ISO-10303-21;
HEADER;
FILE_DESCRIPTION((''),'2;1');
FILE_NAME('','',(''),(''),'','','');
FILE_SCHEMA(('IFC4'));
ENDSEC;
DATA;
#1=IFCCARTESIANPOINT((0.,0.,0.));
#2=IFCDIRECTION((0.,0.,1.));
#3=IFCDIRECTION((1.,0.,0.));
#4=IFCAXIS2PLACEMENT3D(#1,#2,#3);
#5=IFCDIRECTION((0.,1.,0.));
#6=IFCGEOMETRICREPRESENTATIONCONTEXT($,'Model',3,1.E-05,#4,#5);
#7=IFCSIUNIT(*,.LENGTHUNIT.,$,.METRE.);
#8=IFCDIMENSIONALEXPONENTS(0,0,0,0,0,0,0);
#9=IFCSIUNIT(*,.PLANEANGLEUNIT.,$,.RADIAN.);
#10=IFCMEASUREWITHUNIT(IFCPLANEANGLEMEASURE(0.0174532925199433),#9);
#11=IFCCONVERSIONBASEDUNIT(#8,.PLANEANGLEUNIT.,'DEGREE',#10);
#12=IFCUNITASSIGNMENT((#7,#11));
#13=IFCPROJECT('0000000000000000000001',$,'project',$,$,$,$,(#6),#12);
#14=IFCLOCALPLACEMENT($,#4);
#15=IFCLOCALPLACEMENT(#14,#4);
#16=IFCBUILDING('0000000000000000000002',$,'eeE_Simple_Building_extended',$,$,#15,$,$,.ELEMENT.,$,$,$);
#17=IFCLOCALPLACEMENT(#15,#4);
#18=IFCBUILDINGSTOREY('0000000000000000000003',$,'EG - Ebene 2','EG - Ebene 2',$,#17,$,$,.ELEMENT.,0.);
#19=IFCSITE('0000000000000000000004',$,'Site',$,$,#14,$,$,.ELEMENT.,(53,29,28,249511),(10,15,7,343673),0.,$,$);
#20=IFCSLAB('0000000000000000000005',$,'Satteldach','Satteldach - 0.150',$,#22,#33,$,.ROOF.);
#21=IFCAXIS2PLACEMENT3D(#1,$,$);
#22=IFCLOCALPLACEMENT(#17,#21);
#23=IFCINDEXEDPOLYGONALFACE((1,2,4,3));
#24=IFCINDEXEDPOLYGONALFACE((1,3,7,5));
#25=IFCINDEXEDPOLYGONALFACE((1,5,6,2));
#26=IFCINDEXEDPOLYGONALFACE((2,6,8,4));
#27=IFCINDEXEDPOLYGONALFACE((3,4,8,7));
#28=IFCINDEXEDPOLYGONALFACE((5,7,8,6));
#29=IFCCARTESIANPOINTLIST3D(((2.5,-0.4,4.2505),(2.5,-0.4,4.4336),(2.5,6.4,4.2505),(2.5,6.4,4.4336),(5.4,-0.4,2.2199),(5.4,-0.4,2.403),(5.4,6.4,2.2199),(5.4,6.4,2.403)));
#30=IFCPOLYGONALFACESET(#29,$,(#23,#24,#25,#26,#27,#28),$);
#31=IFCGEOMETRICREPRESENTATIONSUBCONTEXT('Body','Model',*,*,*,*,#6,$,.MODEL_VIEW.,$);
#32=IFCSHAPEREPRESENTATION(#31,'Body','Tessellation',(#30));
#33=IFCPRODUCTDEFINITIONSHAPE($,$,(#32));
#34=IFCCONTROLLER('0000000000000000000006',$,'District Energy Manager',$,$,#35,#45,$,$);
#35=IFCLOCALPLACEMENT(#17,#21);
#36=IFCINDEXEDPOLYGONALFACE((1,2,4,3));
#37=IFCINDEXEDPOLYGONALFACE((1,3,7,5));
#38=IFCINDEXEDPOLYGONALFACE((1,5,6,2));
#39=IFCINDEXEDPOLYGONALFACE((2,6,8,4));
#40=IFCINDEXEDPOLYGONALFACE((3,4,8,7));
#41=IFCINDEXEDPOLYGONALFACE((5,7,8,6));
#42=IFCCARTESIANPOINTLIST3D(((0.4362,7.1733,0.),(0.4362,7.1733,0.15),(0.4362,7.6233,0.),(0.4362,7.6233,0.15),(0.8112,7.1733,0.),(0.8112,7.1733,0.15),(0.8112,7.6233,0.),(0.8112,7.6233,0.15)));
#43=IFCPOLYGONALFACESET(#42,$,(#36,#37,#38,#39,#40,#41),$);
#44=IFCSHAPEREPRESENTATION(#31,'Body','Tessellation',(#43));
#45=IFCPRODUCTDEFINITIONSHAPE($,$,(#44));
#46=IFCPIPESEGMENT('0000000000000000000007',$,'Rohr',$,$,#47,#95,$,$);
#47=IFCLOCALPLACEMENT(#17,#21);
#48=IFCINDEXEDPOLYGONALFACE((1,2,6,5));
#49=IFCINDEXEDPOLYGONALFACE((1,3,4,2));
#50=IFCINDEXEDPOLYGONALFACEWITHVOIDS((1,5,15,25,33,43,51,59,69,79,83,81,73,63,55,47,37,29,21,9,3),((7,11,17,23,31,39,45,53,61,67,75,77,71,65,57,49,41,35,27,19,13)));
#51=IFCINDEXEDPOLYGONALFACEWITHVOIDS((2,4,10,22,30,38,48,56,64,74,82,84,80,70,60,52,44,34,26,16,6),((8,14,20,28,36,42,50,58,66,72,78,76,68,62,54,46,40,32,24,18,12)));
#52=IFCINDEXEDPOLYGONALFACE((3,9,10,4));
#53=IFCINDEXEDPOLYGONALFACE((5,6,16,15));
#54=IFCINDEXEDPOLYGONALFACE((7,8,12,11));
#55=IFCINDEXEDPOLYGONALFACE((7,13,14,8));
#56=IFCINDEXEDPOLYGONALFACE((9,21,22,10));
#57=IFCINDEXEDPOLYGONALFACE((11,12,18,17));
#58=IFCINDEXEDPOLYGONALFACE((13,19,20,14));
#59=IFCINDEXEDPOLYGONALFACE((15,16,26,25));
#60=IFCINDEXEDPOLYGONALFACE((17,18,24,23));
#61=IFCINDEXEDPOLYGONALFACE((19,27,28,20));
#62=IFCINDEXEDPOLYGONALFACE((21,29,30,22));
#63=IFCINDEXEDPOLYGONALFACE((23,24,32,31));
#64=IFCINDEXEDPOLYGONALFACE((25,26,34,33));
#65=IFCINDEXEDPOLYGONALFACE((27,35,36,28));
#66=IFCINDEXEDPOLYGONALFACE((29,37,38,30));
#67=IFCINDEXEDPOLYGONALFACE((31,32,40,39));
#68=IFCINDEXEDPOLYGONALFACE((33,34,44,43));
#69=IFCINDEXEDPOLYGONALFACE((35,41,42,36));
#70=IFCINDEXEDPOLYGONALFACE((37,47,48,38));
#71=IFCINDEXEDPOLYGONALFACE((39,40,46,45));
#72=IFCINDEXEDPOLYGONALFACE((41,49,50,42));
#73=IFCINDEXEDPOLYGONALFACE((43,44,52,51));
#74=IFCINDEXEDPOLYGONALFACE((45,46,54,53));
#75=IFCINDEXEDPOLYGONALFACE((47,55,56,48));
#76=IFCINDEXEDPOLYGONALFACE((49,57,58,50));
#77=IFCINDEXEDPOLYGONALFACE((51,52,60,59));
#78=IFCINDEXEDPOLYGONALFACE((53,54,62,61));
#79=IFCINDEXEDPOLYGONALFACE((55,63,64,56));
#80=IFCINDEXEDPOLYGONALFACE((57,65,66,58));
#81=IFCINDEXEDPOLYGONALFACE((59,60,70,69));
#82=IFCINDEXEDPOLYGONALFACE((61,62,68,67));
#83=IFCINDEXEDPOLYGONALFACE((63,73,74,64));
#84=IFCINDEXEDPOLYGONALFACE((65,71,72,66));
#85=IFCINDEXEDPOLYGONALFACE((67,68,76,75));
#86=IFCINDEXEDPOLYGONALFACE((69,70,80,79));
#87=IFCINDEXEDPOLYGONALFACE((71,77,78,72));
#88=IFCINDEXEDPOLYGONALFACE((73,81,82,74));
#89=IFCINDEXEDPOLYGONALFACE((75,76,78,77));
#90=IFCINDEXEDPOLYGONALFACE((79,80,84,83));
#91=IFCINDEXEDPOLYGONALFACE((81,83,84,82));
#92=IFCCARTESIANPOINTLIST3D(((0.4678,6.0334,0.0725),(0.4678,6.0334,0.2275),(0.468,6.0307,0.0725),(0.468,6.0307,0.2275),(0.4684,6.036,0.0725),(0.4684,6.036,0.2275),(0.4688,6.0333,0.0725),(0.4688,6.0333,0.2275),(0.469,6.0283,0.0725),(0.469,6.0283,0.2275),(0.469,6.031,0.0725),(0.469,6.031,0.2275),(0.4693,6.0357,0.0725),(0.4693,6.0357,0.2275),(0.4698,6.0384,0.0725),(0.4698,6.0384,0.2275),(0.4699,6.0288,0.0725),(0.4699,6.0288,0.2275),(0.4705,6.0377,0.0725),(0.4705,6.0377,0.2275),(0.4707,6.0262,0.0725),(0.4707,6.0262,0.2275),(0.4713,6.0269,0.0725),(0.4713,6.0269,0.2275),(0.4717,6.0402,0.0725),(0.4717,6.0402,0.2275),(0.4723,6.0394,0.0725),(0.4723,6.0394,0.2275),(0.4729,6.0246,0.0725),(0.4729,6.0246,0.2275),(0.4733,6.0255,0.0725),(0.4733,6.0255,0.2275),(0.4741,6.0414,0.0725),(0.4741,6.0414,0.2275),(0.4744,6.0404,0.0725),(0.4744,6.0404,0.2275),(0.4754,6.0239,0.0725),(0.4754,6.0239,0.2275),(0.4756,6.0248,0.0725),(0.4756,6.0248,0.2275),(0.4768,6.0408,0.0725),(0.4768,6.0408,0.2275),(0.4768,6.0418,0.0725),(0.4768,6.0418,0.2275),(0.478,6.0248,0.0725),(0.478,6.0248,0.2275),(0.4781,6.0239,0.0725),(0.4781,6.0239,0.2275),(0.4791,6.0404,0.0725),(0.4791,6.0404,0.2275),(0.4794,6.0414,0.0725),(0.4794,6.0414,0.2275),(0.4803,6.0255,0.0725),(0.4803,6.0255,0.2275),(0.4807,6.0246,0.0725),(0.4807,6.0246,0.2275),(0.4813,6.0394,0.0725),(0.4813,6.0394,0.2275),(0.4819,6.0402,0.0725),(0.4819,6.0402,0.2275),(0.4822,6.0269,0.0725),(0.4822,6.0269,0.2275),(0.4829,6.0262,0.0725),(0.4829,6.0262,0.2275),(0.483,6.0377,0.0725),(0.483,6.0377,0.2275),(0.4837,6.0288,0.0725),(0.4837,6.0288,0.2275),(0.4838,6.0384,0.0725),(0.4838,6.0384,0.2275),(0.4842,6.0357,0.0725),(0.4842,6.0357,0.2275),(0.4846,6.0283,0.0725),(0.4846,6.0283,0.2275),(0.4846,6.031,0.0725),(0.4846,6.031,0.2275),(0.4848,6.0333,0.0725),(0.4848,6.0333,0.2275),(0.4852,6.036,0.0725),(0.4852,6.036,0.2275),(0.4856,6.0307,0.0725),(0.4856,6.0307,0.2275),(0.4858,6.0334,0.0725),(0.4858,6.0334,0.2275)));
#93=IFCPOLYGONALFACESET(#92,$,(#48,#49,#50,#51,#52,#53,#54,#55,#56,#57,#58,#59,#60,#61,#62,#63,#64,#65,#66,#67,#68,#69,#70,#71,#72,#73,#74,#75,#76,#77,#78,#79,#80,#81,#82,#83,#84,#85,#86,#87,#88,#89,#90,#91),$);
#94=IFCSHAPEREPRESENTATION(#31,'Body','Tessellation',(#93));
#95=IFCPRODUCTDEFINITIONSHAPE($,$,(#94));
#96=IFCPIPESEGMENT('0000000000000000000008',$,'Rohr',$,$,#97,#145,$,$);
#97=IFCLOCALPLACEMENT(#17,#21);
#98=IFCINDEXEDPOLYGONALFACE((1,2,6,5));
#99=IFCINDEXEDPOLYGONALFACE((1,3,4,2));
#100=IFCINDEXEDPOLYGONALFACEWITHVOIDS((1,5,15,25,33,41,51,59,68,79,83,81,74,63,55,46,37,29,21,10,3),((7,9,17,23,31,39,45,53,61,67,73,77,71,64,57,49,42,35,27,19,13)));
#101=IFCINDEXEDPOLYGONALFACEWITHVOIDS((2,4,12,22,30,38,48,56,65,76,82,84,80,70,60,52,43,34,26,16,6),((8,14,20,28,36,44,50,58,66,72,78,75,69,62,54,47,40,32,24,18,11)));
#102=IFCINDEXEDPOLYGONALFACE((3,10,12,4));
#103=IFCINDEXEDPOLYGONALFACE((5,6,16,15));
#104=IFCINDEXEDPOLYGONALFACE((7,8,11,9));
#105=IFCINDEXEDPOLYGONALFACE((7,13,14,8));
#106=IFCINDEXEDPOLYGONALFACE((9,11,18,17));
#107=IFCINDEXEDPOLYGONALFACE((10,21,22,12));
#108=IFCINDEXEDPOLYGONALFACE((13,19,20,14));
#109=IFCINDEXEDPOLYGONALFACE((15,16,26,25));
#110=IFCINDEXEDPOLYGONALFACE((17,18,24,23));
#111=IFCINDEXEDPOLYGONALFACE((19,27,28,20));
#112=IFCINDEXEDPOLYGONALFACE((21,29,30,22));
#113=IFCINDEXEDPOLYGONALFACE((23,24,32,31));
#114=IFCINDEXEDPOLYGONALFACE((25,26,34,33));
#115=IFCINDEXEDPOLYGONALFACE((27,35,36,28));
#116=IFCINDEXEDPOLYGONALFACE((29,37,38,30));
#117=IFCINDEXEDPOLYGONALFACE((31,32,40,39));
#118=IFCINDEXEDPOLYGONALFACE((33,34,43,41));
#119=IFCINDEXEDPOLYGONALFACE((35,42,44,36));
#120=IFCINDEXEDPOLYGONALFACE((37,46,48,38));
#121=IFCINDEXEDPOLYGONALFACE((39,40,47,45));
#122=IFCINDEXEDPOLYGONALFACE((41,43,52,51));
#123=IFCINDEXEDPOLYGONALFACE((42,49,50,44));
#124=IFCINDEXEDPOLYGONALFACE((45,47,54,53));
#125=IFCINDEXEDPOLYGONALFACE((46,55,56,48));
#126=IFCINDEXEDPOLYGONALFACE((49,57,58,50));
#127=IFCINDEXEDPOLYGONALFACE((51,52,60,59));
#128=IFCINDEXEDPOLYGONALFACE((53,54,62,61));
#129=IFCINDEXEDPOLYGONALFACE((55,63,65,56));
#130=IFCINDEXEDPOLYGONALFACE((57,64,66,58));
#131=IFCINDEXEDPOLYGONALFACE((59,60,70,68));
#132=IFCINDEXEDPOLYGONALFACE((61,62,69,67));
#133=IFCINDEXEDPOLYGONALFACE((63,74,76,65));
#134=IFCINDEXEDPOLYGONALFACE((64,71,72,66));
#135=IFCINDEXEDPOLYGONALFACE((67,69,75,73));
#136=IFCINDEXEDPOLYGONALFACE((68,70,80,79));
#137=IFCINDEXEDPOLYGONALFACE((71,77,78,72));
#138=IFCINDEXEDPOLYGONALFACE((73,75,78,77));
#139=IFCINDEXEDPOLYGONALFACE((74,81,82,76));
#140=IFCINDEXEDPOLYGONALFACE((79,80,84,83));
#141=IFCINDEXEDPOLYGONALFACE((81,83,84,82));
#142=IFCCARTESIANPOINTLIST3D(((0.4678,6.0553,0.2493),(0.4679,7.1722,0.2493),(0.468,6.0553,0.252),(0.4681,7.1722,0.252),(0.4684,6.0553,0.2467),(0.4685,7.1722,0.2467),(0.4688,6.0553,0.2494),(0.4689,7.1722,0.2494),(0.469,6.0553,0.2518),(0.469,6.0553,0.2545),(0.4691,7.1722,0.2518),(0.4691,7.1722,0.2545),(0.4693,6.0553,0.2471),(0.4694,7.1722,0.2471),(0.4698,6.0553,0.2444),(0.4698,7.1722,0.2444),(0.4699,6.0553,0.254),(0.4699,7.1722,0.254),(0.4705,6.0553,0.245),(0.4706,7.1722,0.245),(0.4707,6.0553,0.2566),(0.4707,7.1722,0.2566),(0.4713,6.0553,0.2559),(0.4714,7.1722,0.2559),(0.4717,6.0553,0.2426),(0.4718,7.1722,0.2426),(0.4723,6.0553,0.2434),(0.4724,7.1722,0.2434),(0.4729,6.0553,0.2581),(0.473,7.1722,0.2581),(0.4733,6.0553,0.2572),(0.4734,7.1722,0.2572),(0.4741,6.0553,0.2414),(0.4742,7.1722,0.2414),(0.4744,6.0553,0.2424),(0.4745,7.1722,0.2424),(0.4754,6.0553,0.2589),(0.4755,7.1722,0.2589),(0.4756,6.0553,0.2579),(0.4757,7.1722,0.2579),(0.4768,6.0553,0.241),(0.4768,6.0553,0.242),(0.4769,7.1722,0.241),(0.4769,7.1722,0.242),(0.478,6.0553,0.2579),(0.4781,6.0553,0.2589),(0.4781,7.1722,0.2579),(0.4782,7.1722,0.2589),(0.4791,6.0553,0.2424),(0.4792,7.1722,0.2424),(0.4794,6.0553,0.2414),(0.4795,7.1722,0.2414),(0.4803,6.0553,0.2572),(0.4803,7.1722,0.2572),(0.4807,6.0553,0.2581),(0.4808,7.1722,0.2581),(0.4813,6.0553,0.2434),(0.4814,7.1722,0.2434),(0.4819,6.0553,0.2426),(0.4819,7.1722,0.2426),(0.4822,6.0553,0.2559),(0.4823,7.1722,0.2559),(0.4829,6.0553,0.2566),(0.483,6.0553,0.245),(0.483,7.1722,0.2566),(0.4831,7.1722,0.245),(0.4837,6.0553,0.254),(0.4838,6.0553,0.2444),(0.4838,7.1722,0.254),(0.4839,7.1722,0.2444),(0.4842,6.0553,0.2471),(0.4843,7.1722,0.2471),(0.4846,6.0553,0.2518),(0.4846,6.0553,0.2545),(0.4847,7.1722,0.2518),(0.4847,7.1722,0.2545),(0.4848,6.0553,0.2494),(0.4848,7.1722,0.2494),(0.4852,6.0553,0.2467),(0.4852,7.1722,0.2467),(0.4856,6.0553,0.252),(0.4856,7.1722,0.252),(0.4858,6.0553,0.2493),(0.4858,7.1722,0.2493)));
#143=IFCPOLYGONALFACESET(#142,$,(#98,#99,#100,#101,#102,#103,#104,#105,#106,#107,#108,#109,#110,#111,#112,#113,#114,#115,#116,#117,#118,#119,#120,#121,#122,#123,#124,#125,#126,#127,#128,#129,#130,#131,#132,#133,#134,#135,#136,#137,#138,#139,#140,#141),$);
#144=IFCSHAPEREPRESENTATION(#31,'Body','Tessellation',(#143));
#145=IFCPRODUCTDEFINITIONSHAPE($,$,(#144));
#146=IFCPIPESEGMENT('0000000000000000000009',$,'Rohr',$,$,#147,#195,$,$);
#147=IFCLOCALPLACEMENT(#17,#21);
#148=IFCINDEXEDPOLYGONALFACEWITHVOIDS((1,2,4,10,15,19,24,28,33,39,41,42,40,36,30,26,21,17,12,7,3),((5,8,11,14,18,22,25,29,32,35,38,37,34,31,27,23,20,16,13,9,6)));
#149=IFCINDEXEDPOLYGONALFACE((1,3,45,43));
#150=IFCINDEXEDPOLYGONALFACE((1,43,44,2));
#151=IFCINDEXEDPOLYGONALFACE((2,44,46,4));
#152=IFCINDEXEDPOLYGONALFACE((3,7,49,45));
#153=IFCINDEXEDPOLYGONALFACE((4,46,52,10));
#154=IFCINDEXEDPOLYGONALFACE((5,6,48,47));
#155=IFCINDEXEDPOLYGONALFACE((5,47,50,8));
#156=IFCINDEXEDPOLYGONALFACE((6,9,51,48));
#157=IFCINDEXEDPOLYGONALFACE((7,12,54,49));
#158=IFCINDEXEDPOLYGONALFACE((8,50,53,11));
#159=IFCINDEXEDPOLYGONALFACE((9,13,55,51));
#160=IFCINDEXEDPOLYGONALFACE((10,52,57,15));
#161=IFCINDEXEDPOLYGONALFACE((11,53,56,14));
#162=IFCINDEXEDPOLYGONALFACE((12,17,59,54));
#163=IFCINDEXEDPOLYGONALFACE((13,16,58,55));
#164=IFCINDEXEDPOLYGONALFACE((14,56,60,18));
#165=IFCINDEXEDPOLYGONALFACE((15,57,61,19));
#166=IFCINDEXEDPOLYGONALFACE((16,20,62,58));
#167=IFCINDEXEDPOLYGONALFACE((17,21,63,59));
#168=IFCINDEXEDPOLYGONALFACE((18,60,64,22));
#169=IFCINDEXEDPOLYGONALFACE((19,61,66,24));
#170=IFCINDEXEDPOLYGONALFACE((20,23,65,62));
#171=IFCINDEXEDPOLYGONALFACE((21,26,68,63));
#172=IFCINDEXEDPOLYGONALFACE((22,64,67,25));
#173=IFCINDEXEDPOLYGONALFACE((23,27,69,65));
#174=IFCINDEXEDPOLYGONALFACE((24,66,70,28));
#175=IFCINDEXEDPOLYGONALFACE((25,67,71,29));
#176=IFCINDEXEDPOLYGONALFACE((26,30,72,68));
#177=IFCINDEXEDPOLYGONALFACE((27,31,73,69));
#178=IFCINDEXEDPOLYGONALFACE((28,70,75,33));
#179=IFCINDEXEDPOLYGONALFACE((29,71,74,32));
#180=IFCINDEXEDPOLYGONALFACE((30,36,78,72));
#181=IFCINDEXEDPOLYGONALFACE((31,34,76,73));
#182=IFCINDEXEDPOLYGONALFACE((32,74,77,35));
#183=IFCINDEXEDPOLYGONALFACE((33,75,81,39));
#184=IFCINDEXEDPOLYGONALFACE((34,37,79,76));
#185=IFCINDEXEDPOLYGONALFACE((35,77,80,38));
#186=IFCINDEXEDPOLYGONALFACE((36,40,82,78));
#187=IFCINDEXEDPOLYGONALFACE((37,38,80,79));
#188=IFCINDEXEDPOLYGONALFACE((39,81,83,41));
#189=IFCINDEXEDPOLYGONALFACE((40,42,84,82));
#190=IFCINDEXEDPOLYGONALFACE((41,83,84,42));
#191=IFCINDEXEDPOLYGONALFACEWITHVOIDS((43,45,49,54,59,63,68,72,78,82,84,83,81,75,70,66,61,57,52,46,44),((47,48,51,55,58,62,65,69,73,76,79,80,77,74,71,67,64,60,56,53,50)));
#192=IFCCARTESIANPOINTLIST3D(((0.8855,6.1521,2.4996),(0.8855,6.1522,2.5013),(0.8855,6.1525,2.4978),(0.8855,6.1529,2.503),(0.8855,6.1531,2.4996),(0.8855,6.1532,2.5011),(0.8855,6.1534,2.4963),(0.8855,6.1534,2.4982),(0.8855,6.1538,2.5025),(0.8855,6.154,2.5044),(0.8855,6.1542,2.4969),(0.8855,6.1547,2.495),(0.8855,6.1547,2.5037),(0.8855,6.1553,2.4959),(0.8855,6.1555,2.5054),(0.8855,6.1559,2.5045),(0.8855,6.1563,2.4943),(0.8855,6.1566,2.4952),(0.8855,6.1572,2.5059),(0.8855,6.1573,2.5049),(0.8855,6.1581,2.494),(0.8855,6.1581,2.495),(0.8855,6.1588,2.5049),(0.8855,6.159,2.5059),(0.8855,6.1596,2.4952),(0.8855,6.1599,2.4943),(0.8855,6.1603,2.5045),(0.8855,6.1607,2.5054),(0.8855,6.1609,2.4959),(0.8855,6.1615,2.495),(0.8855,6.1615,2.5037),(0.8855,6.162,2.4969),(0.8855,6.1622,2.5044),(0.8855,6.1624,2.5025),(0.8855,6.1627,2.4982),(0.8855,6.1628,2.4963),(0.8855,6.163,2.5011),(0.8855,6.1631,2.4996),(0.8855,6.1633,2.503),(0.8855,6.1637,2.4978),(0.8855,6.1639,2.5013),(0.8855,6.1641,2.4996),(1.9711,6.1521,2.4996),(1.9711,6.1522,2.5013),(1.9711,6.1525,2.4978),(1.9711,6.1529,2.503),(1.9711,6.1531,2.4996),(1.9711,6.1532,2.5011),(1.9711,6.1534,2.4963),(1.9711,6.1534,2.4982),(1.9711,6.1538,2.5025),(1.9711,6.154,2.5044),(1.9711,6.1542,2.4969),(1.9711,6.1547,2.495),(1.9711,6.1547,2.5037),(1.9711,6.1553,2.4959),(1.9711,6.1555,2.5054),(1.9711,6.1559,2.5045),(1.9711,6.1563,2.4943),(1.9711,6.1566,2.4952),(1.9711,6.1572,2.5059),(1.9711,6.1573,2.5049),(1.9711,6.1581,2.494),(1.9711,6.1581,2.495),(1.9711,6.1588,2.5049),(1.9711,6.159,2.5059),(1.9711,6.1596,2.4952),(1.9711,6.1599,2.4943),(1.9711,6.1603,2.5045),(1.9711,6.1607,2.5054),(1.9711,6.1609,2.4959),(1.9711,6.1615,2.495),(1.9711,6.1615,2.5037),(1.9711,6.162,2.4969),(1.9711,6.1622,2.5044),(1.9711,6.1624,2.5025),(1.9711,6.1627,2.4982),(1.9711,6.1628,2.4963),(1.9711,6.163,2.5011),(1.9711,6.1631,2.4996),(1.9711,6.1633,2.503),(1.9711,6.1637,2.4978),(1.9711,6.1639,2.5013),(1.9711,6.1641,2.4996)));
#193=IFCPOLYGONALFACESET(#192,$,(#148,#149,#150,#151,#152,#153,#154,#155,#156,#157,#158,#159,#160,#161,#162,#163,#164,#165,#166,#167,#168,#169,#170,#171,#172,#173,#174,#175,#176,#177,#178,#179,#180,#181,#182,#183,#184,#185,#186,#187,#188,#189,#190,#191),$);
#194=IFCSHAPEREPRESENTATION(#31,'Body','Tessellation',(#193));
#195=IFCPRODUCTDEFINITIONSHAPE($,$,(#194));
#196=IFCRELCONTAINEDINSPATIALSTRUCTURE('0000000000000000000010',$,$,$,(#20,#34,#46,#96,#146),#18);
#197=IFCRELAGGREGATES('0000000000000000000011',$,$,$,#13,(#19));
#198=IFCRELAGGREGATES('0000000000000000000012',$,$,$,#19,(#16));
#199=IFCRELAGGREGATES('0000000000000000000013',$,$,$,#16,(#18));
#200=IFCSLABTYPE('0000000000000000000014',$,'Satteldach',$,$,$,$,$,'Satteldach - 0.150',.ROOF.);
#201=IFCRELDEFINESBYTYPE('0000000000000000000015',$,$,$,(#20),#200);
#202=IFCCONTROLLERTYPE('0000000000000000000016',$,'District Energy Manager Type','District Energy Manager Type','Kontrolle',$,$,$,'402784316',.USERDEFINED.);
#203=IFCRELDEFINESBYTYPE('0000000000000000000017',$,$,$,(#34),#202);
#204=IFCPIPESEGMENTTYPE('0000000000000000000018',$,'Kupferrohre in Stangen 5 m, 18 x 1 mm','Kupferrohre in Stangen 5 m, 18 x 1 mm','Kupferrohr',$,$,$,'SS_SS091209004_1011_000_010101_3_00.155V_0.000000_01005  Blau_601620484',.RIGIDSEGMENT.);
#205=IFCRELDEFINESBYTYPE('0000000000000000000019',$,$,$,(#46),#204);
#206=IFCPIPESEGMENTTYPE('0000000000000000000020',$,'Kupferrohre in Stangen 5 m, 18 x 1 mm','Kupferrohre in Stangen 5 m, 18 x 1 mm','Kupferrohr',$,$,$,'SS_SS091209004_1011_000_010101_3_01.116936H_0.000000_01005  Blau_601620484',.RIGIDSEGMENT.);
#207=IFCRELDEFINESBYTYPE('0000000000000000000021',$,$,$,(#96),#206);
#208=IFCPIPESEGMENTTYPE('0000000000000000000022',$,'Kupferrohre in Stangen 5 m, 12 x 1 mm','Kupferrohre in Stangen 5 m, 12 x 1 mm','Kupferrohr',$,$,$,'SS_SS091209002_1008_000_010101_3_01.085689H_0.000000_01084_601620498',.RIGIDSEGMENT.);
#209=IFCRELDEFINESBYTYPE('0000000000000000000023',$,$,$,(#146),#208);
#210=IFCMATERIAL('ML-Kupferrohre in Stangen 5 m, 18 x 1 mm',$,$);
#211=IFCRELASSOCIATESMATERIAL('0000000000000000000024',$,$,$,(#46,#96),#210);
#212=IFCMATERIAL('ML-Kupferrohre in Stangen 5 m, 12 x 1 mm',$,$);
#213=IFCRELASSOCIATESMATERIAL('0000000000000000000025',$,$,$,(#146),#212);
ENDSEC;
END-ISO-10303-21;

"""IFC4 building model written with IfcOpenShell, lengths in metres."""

from ifc_helpers import new_model, entity, si_unit, converted_unit, direction, frame, origin_with_axes, origin_2d_with_axis, place, context, subcontext, project, spatial, polyline, rectangle, hollow_circle, outline, extrude, source, transform, mapped, material, type_object, element, save


model = new_model("IFC4")

# Units and contexts
model_context = context("Model", 3, precision=1e-05, world=origin_with_axes(), true_north=direction((0.0, 1.0, 0.0)))
body_context = subcontext(model_context, "Body", "Model", "MODEL_VIEW")
ifc_project = project(units=[si_unit("LENGTHUNIT", "METRE"), converted_unit("PLANEANGLEUNIT", "DEGREE", entity("IfcPlaneAngleMeasure", 0.0174532925199433), si_unit("PLANEANGLEUNIT", "RADIAN"), dimensions=[0, 0, 0, 0, 0, 0, 0])], contexts=[model_context])

# Site, building, storey
site_placement = place(None, origin_with_axes())
site = spatial("IfcSite", under=ifc_project, at=site_placement, Name="Site", CompositionType="ELEMENT", RefLatitude=(53, 29, 28, 249511), RefLongitude=(10, 15, 7, 343673), RefElevation=0.0)
building_placement = place(site_placement, origin_with_axes())
building = spatial("IfcBuilding", under=site, at=building_placement, Name="eeE_Simple_Building_extended", CompositionType="ELEMENT")
storey_placement = place(building_placement, origin_with_axes())
storey = spatial("IfcBuildingStorey", under=building, at=storey_placement, Name="EG - Ebene 2", Description="EG - Ebene 2", CompositionType="ELEMENT", Elevation=0.0)

# Slab
slab_type = type_object("IfcSlabType", Name="Satteldach", ElementType="Satteldach - 0.150", PredefinedType="ROOF")
slab_placement = place(storey_placement, frame((2.5, 6.4, 4.2505), z_axis=(0.573576, 0.0, 0.819152), x_axis=(0.0, -1.0, 0.0)))
element("IfcSlab", 1, at=slab_placement, inside=storey, type_object=slab_type, Name="Satteldach", Description="Satteldach - 0.150", PredefinedType="ROOF", context=body_context, shape_type="SweptSolid", body=[
    extrude(outline(polyline([(0.0, 0.0), (6.8, 0.0), (6.8, 3.5402), (0.0, 3.5402), (0.0, 0.0)])), frame((0.0, 0.0, 0.0), z_axis=(0.0, 0.0, 1.0), x_axis=(1.0, 0.0, 0.0)), (0.0, -0.573576, 0.819152), 0.1831),
])

# Controller
controller_type = type_object("IfcControllerType", Name="District Energy Manager Type", Description="District Energy Manager Type", ApplicableOccurrence="Kontrolle", ElementType="402784316", PredefinedType="USERDEFINED")
shared_shape_1 = source(origin_with_axes(), body_context, "Body", "SweptSolid", [
    extrude(rectangle(XDim=0.375, YDim=0.45, at=origin_2d_with_axis()), frame((0.225, 0.1875, 0.0), z_axis=(0.0, 0.0, 1.0), x_axis=(0.0, 1.0, 0.0)), (0.0, 0.0, 1.0), 0.15),
])
controller_placement = place(storey_placement, frame((0.8112, 7.1733, 0.0), z_axis=(0.0, 0.0, 1.0), x_axis=(0.0, 1.0, 0.0)))
element("IfcController", 2, at=controller_placement, inside=storey, type_object=controller_type, Name="District Energy Manager", context=body_context, shape_type="MappedRepresentation", body=[
    mapped(shared_shape_1, transform((0.0, 0.0, 0.0), x_axis=(1.0, 0.0, 0.0), y_axis=(0.0, 1.0, 0.0), z_axis=(0.0, 0.0, 1.0), scale=1.0)),
])

# Pipe segments
ifc_material_1 = material(Name="ML-Kupferrohre in Stangen 5 m, 18 x 1 mm")
pipe_segment_type_1 = type_object("IfcPipeSegmentType", Name="Kupferrohre in Stangen 5 m, 18 x 1 mm", Description="Kupferrohre in Stangen 5 m, 18 x 1 mm", ApplicableOccurrence="Kupferrohr", ElementType="SS_SS091209004_1011_000_010101_3_00.155V_0.000000_01005  Blau_601620484", PredefinedType="RIGIDSEGMENT")
pipe_segment_1_placement = place(storey_placement, frame((0.4768, 6.0328, 0.0725), z_axis=(0.0, -1.0, 0.0), x_axis=(0.0, 0.0, 1.0)))
element("IfcPipeSegment", 3, at=pipe_segment_1_placement, inside=storey, type_object=pipe_segment_type_1, material=ifc_material_1, Name="Rohr", context=body_context, shape_type="SweptSolid", body=[
    extrude(hollow_circle(Radius=0.009, WallThickness=0.001, at=origin_2d_with_axis()), frame((0.0, 0.0, 0.0), z_axis=(1.0, 0.0, 0.0), x_axis=(0.0, 0.0, -1.0)), (0.0, 0.0, 1.0), 0.155),
])
pipe_segment_type_2 = type_object("IfcPipeSegmentType", Name="Kupferrohre in Stangen 5 m, 18 x 1 mm", Description="Kupferrohre in Stangen 5 m, 18 x 1 mm", ApplicableOccurrence="Kupferrohr", ElementType="SS_SS091209004_1011_000_010101_3_01.116936H_0.000000_01005  Blau_601620484", PredefinedType="RIGIDSEGMENT")
pipe_segment_2_placement = place(storey_placement, frame((0.4768, 6.0553, 0.25), z_axis=(0.0, 0.0, 1.0), x_axis=(0.000061, 1.0, 0.0)))
element("IfcPipeSegment", 4, at=pipe_segment_2_placement, inside=storey, type_object=pipe_segment_type_2, material=ifc_material_1, Name="Rohr", context=body_context, shape_type="SweptSolid", body=[
    extrude(hollow_circle(Radius=0.009, WallThickness=0.001, at=origin_2d_with_axis()), frame((0.0, 0.0, 0.0), z_axis=(1.0, 0.0, 0.0), x_axis=(0.0, 0.0, -1.0)), (0.0, 0.0, 1.0), 1.1169),
])
ifc_material_2 = material(Name="ML-Kupferrohre in Stangen 5 m, 12 x 1 mm")
pipe_segment_type_3 = type_object("IfcPipeSegmentType", Name="Kupferrohre in Stangen 5 m, 12 x 1 mm", Description="Kupferrohre in Stangen 5 m, 12 x 1 mm", ApplicableOccurrence="Kupferrohr", ElementType="SS_SS091209002_1008_000_010101_3_01.085689H_0.000000_01084_601620498", PredefinedType="RIGIDSEGMENT")
pipe_segment_3_placement = place(storey_placement, frame((1.9711, 6.1581, 2.5), z_axis=(0.0, 0.0, 1.0), x_axis=(-1.0, 0.0, 0.0)))
element("IfcPipeSegment", 5, at=pipe_segment_3_placement, inside=storey, type_object=pipe_segment_type_3, material=ifc_material_2, Name="Rohr", context=body_context, shape_type="SweptSolid", body=[
    extrude(hollow_circle(Radius=0.006, WallThickness=0.001, at=origin_2d_with_axis()), frame((0.0, 0.0, 0.0), z_axis=(1.0, 0.0, 0.0), x_axis=(0.0, 0.0, -1.0)), (0.0, 0.0, 1.0), 1.0857),
])

save(model, "model.ifc")
